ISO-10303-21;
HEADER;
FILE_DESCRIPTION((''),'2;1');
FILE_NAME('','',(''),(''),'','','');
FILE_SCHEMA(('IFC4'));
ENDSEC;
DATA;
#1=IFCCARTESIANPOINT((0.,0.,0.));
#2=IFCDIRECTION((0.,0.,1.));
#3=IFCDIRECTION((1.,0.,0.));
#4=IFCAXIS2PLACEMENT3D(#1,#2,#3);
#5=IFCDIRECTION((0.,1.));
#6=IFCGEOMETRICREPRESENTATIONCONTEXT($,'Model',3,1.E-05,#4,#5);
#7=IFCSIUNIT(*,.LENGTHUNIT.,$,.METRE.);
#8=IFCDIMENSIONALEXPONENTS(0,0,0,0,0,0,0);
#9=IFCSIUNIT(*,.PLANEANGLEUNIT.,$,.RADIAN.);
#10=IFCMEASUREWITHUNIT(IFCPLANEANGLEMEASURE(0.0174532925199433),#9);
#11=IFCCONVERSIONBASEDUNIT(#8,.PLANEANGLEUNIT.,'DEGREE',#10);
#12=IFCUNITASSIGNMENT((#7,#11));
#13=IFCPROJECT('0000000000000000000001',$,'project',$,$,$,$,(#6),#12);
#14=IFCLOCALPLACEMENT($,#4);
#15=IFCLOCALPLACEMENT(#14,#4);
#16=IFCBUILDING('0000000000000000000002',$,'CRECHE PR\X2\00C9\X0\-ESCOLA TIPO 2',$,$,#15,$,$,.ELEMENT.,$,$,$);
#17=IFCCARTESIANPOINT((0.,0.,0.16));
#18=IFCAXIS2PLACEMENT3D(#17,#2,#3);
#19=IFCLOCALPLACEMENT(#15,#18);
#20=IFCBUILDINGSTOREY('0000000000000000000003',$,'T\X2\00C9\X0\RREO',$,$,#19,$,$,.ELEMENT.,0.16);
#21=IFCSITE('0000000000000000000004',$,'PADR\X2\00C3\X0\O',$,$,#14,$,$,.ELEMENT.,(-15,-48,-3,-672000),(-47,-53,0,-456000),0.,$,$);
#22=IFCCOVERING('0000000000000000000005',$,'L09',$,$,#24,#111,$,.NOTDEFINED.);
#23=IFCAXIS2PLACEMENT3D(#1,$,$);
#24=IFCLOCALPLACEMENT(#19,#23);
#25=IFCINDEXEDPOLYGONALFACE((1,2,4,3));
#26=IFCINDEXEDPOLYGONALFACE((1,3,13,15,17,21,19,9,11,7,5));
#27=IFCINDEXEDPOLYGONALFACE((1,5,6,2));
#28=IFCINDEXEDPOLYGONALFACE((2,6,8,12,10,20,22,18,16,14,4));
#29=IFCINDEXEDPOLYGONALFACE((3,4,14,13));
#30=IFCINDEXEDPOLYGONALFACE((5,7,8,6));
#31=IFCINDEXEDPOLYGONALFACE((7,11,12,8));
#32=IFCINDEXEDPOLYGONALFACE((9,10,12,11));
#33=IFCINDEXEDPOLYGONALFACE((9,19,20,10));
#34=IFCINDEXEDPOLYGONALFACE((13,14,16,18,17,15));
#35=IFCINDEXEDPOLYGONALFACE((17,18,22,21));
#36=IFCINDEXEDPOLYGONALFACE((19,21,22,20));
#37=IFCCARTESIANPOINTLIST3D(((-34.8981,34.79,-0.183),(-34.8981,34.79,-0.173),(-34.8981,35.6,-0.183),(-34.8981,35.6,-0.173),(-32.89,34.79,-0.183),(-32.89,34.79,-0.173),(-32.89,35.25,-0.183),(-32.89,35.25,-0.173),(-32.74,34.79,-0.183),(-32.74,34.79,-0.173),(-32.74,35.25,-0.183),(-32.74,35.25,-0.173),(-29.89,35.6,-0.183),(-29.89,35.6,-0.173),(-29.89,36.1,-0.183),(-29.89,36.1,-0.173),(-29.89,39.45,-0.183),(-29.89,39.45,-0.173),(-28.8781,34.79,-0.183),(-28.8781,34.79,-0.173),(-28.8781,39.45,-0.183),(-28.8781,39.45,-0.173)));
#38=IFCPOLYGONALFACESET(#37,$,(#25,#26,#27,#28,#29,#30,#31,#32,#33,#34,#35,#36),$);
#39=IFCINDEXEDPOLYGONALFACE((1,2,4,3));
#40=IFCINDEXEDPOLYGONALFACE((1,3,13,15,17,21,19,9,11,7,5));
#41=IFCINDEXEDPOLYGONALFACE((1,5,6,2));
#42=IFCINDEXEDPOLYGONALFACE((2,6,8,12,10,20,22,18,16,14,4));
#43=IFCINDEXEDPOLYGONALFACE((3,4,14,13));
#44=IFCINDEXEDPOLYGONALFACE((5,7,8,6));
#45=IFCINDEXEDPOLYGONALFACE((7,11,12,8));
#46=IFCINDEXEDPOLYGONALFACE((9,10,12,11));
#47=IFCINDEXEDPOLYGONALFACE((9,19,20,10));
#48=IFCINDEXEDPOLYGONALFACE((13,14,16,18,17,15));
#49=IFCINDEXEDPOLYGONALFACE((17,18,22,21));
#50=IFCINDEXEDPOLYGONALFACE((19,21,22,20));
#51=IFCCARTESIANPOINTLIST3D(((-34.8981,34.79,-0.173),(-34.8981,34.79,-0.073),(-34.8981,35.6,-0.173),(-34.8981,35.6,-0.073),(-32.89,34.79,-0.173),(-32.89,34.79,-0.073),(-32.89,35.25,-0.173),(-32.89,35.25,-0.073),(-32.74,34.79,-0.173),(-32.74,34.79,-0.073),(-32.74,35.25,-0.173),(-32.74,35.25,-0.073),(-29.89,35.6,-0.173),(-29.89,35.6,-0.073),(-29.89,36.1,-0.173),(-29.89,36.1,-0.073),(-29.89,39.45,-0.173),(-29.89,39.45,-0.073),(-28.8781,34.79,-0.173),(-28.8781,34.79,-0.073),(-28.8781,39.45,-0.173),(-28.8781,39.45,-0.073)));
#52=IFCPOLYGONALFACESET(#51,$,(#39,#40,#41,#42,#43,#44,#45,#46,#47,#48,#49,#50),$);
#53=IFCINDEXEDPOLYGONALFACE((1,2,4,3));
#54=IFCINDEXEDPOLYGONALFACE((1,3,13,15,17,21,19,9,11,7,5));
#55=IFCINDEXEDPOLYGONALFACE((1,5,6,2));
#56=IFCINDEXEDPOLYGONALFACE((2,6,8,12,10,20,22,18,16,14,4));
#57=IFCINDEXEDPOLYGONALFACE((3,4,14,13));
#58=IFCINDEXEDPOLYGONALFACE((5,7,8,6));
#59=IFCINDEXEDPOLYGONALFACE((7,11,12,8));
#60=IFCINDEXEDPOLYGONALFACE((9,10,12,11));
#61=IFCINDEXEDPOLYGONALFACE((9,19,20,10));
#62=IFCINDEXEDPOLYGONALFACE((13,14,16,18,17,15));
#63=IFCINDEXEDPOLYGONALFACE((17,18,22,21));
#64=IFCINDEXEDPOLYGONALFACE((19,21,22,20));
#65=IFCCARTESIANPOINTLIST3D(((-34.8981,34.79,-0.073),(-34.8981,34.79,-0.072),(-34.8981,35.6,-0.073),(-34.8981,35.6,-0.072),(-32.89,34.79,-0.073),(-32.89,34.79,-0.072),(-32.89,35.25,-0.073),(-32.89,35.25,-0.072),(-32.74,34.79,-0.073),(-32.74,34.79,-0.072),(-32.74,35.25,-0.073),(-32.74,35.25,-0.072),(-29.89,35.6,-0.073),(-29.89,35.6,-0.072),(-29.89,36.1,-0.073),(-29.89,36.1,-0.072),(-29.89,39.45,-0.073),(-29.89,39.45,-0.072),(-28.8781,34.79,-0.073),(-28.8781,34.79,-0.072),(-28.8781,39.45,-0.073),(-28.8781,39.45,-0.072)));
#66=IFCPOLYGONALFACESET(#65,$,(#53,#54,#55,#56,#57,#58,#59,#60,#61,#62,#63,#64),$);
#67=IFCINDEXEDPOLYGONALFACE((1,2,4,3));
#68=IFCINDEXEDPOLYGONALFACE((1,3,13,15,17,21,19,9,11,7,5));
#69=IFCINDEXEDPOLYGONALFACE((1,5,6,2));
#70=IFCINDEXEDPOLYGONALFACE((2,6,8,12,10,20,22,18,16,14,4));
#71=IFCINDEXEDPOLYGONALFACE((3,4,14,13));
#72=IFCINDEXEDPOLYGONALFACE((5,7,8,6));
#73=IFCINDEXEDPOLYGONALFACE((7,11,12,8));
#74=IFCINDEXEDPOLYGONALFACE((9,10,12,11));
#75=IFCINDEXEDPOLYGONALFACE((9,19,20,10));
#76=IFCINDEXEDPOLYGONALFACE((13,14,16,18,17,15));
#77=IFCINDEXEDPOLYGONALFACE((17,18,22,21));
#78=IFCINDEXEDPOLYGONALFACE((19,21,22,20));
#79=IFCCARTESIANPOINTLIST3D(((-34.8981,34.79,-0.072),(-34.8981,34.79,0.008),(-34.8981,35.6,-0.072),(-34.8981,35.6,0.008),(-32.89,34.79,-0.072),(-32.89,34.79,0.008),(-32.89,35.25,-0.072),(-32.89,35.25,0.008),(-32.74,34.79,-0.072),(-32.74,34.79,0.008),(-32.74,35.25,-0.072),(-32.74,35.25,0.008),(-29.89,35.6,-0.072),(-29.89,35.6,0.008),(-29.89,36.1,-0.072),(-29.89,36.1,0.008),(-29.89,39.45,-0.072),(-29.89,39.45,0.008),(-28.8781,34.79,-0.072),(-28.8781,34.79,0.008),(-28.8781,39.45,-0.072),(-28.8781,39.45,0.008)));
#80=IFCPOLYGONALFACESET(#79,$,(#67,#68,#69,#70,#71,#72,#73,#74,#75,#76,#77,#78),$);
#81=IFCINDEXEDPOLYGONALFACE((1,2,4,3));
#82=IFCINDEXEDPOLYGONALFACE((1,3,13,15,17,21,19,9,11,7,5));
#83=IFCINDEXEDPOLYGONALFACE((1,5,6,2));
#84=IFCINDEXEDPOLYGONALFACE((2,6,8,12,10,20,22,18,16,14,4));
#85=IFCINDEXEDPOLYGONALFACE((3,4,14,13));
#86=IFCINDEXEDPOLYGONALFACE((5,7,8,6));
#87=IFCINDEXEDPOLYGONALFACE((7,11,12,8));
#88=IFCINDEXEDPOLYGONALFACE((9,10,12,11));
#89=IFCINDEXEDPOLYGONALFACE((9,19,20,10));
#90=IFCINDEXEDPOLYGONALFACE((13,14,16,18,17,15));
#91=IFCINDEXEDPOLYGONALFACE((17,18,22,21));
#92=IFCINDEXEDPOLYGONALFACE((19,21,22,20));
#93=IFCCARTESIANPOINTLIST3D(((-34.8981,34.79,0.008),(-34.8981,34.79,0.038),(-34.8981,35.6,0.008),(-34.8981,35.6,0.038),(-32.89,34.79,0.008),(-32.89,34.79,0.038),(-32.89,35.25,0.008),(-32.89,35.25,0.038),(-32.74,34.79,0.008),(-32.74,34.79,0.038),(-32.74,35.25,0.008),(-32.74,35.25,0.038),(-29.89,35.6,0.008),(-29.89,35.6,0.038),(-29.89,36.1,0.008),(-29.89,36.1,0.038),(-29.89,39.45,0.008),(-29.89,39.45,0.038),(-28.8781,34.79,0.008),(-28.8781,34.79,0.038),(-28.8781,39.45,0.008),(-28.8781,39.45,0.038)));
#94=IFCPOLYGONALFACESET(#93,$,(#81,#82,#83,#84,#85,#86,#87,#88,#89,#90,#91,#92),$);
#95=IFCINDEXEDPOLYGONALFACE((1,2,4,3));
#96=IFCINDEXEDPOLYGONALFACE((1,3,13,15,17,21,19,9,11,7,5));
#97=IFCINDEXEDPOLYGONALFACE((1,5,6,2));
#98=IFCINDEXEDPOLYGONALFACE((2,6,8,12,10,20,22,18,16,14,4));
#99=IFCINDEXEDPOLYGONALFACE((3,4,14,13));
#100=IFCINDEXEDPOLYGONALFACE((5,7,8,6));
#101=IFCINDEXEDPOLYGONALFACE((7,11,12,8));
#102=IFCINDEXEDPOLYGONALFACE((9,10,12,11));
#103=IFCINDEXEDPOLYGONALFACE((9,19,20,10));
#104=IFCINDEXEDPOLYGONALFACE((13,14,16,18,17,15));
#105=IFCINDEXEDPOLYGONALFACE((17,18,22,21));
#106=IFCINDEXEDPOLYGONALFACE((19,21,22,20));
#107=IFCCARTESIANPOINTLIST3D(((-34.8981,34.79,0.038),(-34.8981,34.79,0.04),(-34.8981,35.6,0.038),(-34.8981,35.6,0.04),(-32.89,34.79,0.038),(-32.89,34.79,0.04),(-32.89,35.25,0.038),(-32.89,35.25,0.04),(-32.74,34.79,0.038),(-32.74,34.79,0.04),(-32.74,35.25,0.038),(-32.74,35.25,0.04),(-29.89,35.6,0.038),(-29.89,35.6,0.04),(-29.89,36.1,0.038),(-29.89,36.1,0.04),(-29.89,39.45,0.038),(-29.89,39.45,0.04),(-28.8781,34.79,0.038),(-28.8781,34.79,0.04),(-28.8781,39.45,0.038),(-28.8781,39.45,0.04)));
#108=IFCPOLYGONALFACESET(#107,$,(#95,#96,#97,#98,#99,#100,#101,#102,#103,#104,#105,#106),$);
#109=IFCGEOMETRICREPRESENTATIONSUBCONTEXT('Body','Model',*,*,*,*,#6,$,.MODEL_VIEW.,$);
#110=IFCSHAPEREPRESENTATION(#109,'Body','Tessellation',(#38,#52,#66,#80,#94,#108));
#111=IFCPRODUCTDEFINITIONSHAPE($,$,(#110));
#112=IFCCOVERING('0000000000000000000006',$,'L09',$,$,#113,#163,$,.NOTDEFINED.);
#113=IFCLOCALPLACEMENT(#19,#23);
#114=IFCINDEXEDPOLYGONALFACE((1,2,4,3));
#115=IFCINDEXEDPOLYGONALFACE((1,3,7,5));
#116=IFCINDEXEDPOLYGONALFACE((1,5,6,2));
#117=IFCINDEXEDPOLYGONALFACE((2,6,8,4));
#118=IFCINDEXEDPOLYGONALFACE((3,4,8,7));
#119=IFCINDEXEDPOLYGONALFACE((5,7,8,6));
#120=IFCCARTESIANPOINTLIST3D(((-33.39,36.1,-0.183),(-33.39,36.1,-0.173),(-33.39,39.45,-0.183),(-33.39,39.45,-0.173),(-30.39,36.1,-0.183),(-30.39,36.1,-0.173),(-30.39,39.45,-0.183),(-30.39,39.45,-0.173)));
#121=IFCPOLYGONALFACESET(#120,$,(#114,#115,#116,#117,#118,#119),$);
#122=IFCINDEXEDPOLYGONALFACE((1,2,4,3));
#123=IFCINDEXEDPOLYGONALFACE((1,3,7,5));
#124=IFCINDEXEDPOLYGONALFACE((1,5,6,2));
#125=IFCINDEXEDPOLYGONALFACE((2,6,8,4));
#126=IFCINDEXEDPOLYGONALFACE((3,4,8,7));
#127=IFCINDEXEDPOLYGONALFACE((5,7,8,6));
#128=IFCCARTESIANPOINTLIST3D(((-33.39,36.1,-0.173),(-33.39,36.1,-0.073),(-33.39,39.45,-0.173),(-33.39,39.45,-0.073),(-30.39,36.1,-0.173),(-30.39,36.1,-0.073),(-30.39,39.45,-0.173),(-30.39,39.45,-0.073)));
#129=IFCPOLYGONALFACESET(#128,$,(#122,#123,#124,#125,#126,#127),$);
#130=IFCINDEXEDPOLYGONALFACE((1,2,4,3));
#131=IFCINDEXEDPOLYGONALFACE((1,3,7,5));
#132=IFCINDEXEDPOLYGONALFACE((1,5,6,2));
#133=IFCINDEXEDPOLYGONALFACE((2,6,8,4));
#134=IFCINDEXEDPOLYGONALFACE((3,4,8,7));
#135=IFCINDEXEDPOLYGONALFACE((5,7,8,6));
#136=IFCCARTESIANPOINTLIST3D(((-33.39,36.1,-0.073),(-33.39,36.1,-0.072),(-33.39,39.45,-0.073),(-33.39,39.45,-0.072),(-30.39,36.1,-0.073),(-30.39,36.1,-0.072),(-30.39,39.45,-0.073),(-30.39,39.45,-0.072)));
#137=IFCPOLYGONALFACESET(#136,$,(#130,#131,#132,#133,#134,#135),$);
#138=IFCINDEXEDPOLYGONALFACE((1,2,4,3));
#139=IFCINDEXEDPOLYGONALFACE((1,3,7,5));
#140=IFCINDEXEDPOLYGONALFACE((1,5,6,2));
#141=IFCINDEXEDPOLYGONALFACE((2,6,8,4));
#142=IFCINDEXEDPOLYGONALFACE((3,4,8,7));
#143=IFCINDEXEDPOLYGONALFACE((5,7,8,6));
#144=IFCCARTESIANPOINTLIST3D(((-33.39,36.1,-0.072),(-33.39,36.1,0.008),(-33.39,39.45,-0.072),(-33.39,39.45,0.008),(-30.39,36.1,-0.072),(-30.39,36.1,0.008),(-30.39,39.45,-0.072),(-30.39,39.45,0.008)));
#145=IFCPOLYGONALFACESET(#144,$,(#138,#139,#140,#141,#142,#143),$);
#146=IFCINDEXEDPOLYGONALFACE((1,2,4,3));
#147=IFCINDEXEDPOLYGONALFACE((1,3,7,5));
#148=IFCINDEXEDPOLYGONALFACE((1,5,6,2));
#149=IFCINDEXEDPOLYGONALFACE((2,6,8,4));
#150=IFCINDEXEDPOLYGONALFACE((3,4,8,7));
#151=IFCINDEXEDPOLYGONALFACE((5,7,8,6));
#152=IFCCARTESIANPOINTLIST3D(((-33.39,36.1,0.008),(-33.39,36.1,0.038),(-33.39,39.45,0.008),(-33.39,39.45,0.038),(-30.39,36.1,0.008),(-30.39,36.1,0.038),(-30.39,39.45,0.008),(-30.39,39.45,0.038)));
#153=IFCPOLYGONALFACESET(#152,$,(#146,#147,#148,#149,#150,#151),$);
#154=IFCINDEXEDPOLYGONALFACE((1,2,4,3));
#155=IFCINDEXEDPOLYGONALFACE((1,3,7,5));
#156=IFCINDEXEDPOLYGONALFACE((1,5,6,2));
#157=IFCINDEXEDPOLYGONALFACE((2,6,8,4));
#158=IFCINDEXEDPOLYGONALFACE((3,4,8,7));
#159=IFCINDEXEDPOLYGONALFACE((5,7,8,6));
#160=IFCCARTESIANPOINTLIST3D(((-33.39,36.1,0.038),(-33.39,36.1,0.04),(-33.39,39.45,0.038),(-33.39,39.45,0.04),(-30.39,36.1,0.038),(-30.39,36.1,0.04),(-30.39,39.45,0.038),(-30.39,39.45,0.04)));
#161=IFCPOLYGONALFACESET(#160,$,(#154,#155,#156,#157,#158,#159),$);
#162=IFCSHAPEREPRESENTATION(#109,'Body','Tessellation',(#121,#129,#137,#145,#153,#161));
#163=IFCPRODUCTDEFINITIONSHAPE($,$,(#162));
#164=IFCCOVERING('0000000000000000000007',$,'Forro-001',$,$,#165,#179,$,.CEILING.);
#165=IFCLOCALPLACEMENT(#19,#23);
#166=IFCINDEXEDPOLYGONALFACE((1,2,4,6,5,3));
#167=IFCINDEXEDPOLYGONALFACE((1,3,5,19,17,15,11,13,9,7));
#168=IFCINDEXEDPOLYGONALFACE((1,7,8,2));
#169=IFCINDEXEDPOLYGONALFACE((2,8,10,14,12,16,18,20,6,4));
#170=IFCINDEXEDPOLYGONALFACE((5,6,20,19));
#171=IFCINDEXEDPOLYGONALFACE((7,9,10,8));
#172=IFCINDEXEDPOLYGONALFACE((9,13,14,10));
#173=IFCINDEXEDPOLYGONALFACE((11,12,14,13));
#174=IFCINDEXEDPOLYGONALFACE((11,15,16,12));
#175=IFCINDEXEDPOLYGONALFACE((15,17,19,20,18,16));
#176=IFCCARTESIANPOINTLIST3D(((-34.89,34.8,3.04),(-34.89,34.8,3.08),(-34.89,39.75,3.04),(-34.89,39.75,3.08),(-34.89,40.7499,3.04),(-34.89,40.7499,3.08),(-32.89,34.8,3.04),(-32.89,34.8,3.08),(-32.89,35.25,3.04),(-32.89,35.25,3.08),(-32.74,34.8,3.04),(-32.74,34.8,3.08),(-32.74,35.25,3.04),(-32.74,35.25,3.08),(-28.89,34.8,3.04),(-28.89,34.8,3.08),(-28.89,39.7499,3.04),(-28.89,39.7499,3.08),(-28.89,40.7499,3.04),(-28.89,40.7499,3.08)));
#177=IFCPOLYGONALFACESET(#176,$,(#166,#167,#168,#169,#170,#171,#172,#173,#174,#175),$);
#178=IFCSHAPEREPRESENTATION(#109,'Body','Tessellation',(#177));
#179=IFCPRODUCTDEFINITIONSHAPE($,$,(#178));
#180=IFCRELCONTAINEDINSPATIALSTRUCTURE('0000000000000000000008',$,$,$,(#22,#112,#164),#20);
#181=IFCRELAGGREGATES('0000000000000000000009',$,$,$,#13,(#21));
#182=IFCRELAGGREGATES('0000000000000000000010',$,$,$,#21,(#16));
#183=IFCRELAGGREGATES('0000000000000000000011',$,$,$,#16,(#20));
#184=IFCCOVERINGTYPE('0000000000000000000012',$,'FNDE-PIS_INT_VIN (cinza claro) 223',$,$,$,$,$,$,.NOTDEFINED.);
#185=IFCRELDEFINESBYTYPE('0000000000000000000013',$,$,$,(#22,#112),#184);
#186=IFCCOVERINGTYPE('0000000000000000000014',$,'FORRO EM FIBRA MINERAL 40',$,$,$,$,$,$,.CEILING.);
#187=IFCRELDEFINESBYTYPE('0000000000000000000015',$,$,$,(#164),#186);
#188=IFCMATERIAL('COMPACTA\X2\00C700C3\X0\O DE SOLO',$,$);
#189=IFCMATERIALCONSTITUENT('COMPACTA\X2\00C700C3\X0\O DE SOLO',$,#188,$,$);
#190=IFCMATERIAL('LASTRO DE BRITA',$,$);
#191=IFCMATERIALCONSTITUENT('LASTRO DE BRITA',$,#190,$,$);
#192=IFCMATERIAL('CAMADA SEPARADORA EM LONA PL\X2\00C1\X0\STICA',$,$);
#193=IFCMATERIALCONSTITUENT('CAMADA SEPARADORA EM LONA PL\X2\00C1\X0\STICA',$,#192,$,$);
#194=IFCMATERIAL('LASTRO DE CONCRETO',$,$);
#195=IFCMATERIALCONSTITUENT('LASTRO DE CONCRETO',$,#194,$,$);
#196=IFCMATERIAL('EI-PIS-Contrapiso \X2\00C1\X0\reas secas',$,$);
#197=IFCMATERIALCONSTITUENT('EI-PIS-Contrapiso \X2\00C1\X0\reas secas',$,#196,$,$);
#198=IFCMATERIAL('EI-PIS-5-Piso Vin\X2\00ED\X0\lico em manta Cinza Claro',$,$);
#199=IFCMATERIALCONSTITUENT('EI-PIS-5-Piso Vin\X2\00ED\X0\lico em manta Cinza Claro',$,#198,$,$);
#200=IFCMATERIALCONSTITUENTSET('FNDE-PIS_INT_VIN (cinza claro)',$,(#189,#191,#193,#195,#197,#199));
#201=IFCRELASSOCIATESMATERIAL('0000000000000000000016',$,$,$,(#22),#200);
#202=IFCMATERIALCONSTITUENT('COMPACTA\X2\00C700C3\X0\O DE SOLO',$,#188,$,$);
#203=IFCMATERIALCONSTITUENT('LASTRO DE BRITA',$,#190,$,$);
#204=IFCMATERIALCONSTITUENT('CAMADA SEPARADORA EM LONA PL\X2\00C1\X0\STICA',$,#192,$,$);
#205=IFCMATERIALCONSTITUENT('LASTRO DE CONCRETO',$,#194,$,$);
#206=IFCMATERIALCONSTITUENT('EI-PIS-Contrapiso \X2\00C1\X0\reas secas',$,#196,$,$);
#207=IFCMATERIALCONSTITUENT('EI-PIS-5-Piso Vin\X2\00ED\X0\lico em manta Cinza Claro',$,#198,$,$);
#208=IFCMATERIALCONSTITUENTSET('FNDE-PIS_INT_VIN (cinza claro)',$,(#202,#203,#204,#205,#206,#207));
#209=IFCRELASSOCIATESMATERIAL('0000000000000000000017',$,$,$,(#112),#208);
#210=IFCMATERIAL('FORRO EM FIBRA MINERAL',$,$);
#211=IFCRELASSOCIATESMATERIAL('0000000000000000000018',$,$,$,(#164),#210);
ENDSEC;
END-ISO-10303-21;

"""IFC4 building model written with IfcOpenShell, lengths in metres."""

from ifc_helpers import new_model, entity, si_unit, converted_unit, direction, frame, origin_with_axes, place, context, subcontext, project, spatial, line, indexed_curve, outline, extrude, material, constituent, constituent_set, type_object, element, save


model = new_model("IFC4")

# Units and contexts
model_context = context("Model", 3, precision=1e-05, world=origin_with_axes(), true_north=direction((0.0, 1.0)))
body_context = subcontext(model_context, "Body", "Model", "MODEL_VIEW")
ifc_project = project(units=[si_unit("LENGTHUNIT", "METRE"), converted_unit("PLANEANGLEUNIT", "DEGREE", entity("IfcPlaneAngleMeasure", 0.0174532925199433), si_unit("PLANEANGLEUNIT", "RADIAN"), dimensions=[0, 0, 0, 0, 0, 0, 0])], contexts=[model_context])

# Site, building, storey
site_placement = place(None, origin_with_axes())
site = spatial("IfcSite", under=ifc_project, at=site_placement, Name="PADRÃO", CompositionType="ELEMENT", RefLatitude=(-15, -48, -3, -672000), RefLongitude=(-47, -53, 0, -456000), RefElevation=0.0)
building_placement = place(site_placement, origin_with_axes())
building = spatial("IfcBuilding", under=site, at=building_placement, Name="CRECHE PRÉ-ESCOLA TIPO 2", CompositionType="ELEMENT")
storey_placement = place(building_placement, frame((0.0, 0.0, 0.16), z_axis=(0.0, 0.0, 1.0), x_axis=(1.0, 0.0, 0.0)))
storey = spatial("IfcBuildingStorey", under=building, at=storey_placement, Name="TÉRREO", CompositionType="ELEMENT", Elevation=0.16)

# Coverings
ifc_material_1 = material(Name="COMPACTAÇÃO DE SOLO")
ifc_material_2 = material(Name="LASTRO DE BRITA")
ifc_material_3 = material(Name="CAMADA SEPARADORA EM LONA PLÁSTICA")
ifc_material_4 = material(Name="LASTRO DE CONCRETO")
ifc_material_5 = material(Name="EI-PIS-Contrapiso Áreas secas")
ifc_material_6 = material(Name="EI-PIS-5-Piso Vinílico em manta Cinza Claro")
covering_type_1 = type_object("IfcCoveringType", Name="FNDE-PIS_INT_VIN (cinza claro) 223", PredefinedType="NOTDEFINED")
ifc_constituent_1 = constituent(ifc_material_1, Name="COMPACTAÇÃO DE SOLO")
ifc_constituent_2 = constituent(ifc_material_2, Name="LASTRO DE BRITA")
ifc_constituent_3 = constituent(ifc_material_3, Name="CAMADA SEPARADORA EM LONA PLÁSTICA")
ifc_constituent_4 = constituent(ifc_material_4, Name="LASTRO DE CONCRETO")
ifc_constituent_5 = constituent(ifc_material_5, Name="EI-PIS-Contrapiso Áreas secas")
ifc_constituent_6 = constituent(ifc_material_6, Name="EI-PIS-5-Piso Vinílico em manta Cinza Claro")
ifc_constituent_set_1 = constituent_set(constituents=[ifc_constituent_1, ifc_constituent_2, ifc_constituent_3, ifc_constituent_4, ifc_constituent_5, ifc_constituent_6], Name="FNDE-PIS_INT_VIN (cinza claro)")
covering_1_placement = place(storey_placement, frame((-34.8981, 34.79, 0.04), z_axis=(0.0, 0.0, 1.0), x_axis=(1.0, 0.0, 0.0)))
element("IfcCovering", 1, at=covering_1_placement, inside=storey, type_object=covering_type_1, material=ifc_constituent_set_1, Name="L09", PredefinedType="NOTDEFINED", context=body_context, shape_type="SweptSolid", body=[
    extrude(outline(indexed_curve([(0.0, 0.0), (2.0081, 0.0), (2.0081, 0.46), (2.1581, 0.46), (2.1581, 0.0), (6.02, 0.0), (6.02, 4.66), (5.0081, 4.66), (5.0081, 1.31), (5.0081, 0.81), (0.0, 0.81)], segments=[line(1, 2, 3, 4, 5, 6, 7, 8, 9, 10, 11, 1)])), frame((0.0, 0.0, -0.223), z_axis=(0.0, 0.0, 1.0), x_axis=(1.0, 0.0, 0.0)), (0.0, 0.0, 1.0), 0.01),
    extrude(outline(indexed_curve([(0.0, 0.0), (2.0081, 0.0), (2.0081, 0.46), (2.1581, 0.46), (2.1581, 0.0), (6.02, 0.0), (6.02, 4.66), (5.0081, 4.66), (5.0081, 1.31), (5.0081, 0.81), (0.0, 0.81)], segments=[line(1, 2, 3, 4, 5, 6, 7, 8, 9, 10, 11, 1)])), frame((0.0, 0.0, -0.213), z_axis=(0.0, 0.0, 1.0), x_axis=(1.0, 0.0, 0.0)), (0.0, 0.0, 1.0), 0.1),
    extrude(outline(indexed_curve([(0.0, 0.0), (2.0081, 0.0), (2.0081, 0.46), (2.1581, 0.46), (2.1581, 0.0), (6.02, 0.0), (6.02, 4.66), (5.0081, 4.66), (5.0081, 1.31), (5.0081, 0.81), (0.0, 0.81)], segments=[line(1, 2, 3, 4, 5, 6, 7, 8, 9, 10, 11, 1)])), frame((0.0, 0.0, -0.113), z_axis=(0.0, 0.0, 1.0), x_axis=(1.0, 0.0, 0.0)), (0.0, 0.0, 1.0), 0.001),
    extrude(outline(indexed_curve([(0.0, 0.0), (2.0081, 0.0), (2.0081, 0.46), (2.1581, 0.46), (2.1581, 0.0), (6.02, 0.0), (6.02, 4.66), (5.0081, 4.66), (5.0081, 1.31), (5.0081, 0.81), (0.0, 0.81)], segments=[line(1, 2, 3, 4, 5, 6, 7, 8, 9, 10, 11, 1)])), frame((0.0, 0.0, -0.112), z_axis=(0.0, 0.0, 1.0), x_axis=(1.0, 0.0, 0.0)), (0.0, 0.0, 1.0), 0.08),
    extrude(outline(indexed_curve([(0.0, 0.0), (2.0081, 0.0), (2.0081, 0.46), (2.1581, 0.46), (2.1581, 0.0), (6.02, 0.0), (6.02, 4.66), (5.0081, 4.66), (5.0081, 1.31), (5.0081, 0.81), (0.0, 0.81)], segments=[line(1, 2, 3, 4, 5, 6, 7, 8, 9, 10, 11, 1)])), frame((0.0, 0.0, -0.032), z_axis=(0.0, 0.0, 1.0), x_axis=(1.0, 0.0, 0.0)), (0.0, 0.0, 1.0), 0.03),
    extrude(outline(indexed_curve([(0.0, 0.0), (2.0081, 0.0), (2.0081, 0.46), (2.1581, 0.46), (2.1581, 0.0), (6.02, 0.0), (6.02, 4.66), (5.0081, 4.66), (5.0081, 1.31), (5.0081, 0.81), (0.0, 0.81)], segments=[line(1, 2, 3, 4, 5, 6, 7, 8, 9, 10, 11, 1)])), frame((0.0, 0.0, -0.002), z_axis=(0.0, 0.0, 1.0), x_axis=(1.0, 0.0, 0.0)), (0.0, 0.0, 1.0), 0.002),
])
ifc_constituent_7 = constituent(ifc_material_1, Name="COMPACTAÇÃO DE SOLO")
ifc_constituent_8 = constituent(ifc_material_2, Name="LASTRO DE BRITA")
ifc_constituent_9 = constituent(ifc_material_3, Name="CAMADA SEPARADORA EM LONA PLÁSTICA")
ifc_constituent_10 = constituent(ifc_material_4, Name="LASTRO DE CONCRETO")
ifc_constituent_11 = constituent(ifc_material_5, Name="EI-PIS-Contrapiso Áreas secas")
ifc_constituent_12 = constituent(ifc_material_6, Name="EI-PIS-5-Piso Vinílico em manta Cinza Claro")
ifc_constituent_set_2 = constituent_set(constituents=[ifc_constituent_7, ifc_constituent_8, ifc_constituent_9, ifc_constituent_10, ifc_constituent_11, ifc_constituent_12], Name="FNDE-PIS_INT_VIN (cinza claro)")
covering_2_placement = place(storey_placement, frame((-33.39, 39.45, 0.04), z_axis=(0.0, 0.0, 1.0), x_axis=(1.0, 0.0, 0.0)))
element("IfcCovering", 2, at=covering_2_placement, inside=storey, type_object=covering_type_1, material=ifc_constituent_set_2, Name="L09", PredefinedType="NOTDEFINED", context=body_context, shape_type="SweptSolid", body=[
    extrude(outline(indexed_curve([(0.0, 0.0), (0.0, -3.35), (3.0, -3.35), (3.0, 0.0)], segments=[line(1, 2, 3, 4, 1)])), frame((0.0, 0.0, -0.223), z_axis=(0.0, 0.0, 1.0), x_axis=(1.0, 0.0, 0.0)), (0.0, 0.0, 1.0), 0.01),
    extrude(outline(indexed_curve([(0.0, 0.0), (0.0, -3.35), (3.0, -3.35), (3.0, 0.0)], segments=[line(1, 2, 3, 4, 1)])), frame((0.0, 0.0, -0.213), z_axis=(0.0, 0.0, 1.0), x_axis=(1.0, 0.0, 0.0)), (0.0, 0.0, 1.0), 0.1),
    extrude(outline(indexed_curve([(0.0, 0.0), (0.0, -3.35), (3.0, -3.35), (3.0, 0.0)], segments=[line(1, 2, 3, 4, 1)])), frame((0.0, 0.0, -0.113), z_axis=(0.0, 0.0, 1.0), x_axis=(1.0, 0.0, 0.0)), (0.0, 0.0, 1.0), 0.001),
    extrude(outline(indexed_curve([(0.0, 0.0), (0.0, -3.35), (3.0, -3.35), (3.0, 0.0)], segments=[line(1, 2, 3, 4, 1)])), frame((0.0, 0.0, -0.112), z_axis=(0.0, 0.0, 1.0), x_axis=(1.0, 0.0, 0.0)), (0.0, 0.0, 1.0), 0.08),
    extrude(outline(indexed_curve([(0.0, 0.0), (0.0, -3.35), (3.0, -3.35), (3.0, 0.0)], segments=[line(1, 2, 3, 4, 1)])), frame((0.0, 0.0, -0.032), z_axis=(0.0, 0.0, 1.0), x_axis=(1.0, 0.0, 0.0)), (0.0, 0.0, 1.0), 0.03),
    extrude(outline(indexed_curve([(0.0, 0.0), (0.0, -3.35), (3.0, -3.35), (3.0, 0.0)], segments=[line(1, 2, 3, 4, 1)])), frame((0.0, 0.0, -0.002), z_axis=(0.0, 0.0, 1.0), x_axis=(1.0, 0.0, 0.0)), (0.0, 0.0, 1.0), 0.002),
])
ifc_material_7 = material(Name="FORRO EM FIBRA MINERAL")
covering_type_2 = type_object("IfcCoveringType", Name="FORRO EM FIBRA MINERAL 40", PredefinedType="CEILING")
covering_3_placement = place(storey_placement, frame((-34.89, 34.8, 3.04), z_axis=(0.0, 0.0, 1.0), x_axis=(1.0, 0.0, 0.0)))
element("IfcCovering", 3, at=covering_3_placement, inside=storey, type_object=covering_type_2, material=ifc_material_7, Name="Forro-001", PredefinedType="CEILING", context=body_context, shape_type="SweptSolid", body=[
    extrude(outline(indexed_curve([(0.0, 0.0), (2.0, 0.0), (2.0, 0.45), (2.15, 0.45), (2.15, 0.0), (6.0, 0.0), (6.0, 4.9499), (6.0, 4.9499), (6.0, 5.9499), (0.0, 5.9499), (0.0, 4.95)], segments=[line(1, 2, 3, 4, 5, 6, 7, 8, 9, 10, 11, 1)])), origin_with_axes(), (0.0, 0.0, 1.0), 0.04),
])

save(model, "model.ifc")
